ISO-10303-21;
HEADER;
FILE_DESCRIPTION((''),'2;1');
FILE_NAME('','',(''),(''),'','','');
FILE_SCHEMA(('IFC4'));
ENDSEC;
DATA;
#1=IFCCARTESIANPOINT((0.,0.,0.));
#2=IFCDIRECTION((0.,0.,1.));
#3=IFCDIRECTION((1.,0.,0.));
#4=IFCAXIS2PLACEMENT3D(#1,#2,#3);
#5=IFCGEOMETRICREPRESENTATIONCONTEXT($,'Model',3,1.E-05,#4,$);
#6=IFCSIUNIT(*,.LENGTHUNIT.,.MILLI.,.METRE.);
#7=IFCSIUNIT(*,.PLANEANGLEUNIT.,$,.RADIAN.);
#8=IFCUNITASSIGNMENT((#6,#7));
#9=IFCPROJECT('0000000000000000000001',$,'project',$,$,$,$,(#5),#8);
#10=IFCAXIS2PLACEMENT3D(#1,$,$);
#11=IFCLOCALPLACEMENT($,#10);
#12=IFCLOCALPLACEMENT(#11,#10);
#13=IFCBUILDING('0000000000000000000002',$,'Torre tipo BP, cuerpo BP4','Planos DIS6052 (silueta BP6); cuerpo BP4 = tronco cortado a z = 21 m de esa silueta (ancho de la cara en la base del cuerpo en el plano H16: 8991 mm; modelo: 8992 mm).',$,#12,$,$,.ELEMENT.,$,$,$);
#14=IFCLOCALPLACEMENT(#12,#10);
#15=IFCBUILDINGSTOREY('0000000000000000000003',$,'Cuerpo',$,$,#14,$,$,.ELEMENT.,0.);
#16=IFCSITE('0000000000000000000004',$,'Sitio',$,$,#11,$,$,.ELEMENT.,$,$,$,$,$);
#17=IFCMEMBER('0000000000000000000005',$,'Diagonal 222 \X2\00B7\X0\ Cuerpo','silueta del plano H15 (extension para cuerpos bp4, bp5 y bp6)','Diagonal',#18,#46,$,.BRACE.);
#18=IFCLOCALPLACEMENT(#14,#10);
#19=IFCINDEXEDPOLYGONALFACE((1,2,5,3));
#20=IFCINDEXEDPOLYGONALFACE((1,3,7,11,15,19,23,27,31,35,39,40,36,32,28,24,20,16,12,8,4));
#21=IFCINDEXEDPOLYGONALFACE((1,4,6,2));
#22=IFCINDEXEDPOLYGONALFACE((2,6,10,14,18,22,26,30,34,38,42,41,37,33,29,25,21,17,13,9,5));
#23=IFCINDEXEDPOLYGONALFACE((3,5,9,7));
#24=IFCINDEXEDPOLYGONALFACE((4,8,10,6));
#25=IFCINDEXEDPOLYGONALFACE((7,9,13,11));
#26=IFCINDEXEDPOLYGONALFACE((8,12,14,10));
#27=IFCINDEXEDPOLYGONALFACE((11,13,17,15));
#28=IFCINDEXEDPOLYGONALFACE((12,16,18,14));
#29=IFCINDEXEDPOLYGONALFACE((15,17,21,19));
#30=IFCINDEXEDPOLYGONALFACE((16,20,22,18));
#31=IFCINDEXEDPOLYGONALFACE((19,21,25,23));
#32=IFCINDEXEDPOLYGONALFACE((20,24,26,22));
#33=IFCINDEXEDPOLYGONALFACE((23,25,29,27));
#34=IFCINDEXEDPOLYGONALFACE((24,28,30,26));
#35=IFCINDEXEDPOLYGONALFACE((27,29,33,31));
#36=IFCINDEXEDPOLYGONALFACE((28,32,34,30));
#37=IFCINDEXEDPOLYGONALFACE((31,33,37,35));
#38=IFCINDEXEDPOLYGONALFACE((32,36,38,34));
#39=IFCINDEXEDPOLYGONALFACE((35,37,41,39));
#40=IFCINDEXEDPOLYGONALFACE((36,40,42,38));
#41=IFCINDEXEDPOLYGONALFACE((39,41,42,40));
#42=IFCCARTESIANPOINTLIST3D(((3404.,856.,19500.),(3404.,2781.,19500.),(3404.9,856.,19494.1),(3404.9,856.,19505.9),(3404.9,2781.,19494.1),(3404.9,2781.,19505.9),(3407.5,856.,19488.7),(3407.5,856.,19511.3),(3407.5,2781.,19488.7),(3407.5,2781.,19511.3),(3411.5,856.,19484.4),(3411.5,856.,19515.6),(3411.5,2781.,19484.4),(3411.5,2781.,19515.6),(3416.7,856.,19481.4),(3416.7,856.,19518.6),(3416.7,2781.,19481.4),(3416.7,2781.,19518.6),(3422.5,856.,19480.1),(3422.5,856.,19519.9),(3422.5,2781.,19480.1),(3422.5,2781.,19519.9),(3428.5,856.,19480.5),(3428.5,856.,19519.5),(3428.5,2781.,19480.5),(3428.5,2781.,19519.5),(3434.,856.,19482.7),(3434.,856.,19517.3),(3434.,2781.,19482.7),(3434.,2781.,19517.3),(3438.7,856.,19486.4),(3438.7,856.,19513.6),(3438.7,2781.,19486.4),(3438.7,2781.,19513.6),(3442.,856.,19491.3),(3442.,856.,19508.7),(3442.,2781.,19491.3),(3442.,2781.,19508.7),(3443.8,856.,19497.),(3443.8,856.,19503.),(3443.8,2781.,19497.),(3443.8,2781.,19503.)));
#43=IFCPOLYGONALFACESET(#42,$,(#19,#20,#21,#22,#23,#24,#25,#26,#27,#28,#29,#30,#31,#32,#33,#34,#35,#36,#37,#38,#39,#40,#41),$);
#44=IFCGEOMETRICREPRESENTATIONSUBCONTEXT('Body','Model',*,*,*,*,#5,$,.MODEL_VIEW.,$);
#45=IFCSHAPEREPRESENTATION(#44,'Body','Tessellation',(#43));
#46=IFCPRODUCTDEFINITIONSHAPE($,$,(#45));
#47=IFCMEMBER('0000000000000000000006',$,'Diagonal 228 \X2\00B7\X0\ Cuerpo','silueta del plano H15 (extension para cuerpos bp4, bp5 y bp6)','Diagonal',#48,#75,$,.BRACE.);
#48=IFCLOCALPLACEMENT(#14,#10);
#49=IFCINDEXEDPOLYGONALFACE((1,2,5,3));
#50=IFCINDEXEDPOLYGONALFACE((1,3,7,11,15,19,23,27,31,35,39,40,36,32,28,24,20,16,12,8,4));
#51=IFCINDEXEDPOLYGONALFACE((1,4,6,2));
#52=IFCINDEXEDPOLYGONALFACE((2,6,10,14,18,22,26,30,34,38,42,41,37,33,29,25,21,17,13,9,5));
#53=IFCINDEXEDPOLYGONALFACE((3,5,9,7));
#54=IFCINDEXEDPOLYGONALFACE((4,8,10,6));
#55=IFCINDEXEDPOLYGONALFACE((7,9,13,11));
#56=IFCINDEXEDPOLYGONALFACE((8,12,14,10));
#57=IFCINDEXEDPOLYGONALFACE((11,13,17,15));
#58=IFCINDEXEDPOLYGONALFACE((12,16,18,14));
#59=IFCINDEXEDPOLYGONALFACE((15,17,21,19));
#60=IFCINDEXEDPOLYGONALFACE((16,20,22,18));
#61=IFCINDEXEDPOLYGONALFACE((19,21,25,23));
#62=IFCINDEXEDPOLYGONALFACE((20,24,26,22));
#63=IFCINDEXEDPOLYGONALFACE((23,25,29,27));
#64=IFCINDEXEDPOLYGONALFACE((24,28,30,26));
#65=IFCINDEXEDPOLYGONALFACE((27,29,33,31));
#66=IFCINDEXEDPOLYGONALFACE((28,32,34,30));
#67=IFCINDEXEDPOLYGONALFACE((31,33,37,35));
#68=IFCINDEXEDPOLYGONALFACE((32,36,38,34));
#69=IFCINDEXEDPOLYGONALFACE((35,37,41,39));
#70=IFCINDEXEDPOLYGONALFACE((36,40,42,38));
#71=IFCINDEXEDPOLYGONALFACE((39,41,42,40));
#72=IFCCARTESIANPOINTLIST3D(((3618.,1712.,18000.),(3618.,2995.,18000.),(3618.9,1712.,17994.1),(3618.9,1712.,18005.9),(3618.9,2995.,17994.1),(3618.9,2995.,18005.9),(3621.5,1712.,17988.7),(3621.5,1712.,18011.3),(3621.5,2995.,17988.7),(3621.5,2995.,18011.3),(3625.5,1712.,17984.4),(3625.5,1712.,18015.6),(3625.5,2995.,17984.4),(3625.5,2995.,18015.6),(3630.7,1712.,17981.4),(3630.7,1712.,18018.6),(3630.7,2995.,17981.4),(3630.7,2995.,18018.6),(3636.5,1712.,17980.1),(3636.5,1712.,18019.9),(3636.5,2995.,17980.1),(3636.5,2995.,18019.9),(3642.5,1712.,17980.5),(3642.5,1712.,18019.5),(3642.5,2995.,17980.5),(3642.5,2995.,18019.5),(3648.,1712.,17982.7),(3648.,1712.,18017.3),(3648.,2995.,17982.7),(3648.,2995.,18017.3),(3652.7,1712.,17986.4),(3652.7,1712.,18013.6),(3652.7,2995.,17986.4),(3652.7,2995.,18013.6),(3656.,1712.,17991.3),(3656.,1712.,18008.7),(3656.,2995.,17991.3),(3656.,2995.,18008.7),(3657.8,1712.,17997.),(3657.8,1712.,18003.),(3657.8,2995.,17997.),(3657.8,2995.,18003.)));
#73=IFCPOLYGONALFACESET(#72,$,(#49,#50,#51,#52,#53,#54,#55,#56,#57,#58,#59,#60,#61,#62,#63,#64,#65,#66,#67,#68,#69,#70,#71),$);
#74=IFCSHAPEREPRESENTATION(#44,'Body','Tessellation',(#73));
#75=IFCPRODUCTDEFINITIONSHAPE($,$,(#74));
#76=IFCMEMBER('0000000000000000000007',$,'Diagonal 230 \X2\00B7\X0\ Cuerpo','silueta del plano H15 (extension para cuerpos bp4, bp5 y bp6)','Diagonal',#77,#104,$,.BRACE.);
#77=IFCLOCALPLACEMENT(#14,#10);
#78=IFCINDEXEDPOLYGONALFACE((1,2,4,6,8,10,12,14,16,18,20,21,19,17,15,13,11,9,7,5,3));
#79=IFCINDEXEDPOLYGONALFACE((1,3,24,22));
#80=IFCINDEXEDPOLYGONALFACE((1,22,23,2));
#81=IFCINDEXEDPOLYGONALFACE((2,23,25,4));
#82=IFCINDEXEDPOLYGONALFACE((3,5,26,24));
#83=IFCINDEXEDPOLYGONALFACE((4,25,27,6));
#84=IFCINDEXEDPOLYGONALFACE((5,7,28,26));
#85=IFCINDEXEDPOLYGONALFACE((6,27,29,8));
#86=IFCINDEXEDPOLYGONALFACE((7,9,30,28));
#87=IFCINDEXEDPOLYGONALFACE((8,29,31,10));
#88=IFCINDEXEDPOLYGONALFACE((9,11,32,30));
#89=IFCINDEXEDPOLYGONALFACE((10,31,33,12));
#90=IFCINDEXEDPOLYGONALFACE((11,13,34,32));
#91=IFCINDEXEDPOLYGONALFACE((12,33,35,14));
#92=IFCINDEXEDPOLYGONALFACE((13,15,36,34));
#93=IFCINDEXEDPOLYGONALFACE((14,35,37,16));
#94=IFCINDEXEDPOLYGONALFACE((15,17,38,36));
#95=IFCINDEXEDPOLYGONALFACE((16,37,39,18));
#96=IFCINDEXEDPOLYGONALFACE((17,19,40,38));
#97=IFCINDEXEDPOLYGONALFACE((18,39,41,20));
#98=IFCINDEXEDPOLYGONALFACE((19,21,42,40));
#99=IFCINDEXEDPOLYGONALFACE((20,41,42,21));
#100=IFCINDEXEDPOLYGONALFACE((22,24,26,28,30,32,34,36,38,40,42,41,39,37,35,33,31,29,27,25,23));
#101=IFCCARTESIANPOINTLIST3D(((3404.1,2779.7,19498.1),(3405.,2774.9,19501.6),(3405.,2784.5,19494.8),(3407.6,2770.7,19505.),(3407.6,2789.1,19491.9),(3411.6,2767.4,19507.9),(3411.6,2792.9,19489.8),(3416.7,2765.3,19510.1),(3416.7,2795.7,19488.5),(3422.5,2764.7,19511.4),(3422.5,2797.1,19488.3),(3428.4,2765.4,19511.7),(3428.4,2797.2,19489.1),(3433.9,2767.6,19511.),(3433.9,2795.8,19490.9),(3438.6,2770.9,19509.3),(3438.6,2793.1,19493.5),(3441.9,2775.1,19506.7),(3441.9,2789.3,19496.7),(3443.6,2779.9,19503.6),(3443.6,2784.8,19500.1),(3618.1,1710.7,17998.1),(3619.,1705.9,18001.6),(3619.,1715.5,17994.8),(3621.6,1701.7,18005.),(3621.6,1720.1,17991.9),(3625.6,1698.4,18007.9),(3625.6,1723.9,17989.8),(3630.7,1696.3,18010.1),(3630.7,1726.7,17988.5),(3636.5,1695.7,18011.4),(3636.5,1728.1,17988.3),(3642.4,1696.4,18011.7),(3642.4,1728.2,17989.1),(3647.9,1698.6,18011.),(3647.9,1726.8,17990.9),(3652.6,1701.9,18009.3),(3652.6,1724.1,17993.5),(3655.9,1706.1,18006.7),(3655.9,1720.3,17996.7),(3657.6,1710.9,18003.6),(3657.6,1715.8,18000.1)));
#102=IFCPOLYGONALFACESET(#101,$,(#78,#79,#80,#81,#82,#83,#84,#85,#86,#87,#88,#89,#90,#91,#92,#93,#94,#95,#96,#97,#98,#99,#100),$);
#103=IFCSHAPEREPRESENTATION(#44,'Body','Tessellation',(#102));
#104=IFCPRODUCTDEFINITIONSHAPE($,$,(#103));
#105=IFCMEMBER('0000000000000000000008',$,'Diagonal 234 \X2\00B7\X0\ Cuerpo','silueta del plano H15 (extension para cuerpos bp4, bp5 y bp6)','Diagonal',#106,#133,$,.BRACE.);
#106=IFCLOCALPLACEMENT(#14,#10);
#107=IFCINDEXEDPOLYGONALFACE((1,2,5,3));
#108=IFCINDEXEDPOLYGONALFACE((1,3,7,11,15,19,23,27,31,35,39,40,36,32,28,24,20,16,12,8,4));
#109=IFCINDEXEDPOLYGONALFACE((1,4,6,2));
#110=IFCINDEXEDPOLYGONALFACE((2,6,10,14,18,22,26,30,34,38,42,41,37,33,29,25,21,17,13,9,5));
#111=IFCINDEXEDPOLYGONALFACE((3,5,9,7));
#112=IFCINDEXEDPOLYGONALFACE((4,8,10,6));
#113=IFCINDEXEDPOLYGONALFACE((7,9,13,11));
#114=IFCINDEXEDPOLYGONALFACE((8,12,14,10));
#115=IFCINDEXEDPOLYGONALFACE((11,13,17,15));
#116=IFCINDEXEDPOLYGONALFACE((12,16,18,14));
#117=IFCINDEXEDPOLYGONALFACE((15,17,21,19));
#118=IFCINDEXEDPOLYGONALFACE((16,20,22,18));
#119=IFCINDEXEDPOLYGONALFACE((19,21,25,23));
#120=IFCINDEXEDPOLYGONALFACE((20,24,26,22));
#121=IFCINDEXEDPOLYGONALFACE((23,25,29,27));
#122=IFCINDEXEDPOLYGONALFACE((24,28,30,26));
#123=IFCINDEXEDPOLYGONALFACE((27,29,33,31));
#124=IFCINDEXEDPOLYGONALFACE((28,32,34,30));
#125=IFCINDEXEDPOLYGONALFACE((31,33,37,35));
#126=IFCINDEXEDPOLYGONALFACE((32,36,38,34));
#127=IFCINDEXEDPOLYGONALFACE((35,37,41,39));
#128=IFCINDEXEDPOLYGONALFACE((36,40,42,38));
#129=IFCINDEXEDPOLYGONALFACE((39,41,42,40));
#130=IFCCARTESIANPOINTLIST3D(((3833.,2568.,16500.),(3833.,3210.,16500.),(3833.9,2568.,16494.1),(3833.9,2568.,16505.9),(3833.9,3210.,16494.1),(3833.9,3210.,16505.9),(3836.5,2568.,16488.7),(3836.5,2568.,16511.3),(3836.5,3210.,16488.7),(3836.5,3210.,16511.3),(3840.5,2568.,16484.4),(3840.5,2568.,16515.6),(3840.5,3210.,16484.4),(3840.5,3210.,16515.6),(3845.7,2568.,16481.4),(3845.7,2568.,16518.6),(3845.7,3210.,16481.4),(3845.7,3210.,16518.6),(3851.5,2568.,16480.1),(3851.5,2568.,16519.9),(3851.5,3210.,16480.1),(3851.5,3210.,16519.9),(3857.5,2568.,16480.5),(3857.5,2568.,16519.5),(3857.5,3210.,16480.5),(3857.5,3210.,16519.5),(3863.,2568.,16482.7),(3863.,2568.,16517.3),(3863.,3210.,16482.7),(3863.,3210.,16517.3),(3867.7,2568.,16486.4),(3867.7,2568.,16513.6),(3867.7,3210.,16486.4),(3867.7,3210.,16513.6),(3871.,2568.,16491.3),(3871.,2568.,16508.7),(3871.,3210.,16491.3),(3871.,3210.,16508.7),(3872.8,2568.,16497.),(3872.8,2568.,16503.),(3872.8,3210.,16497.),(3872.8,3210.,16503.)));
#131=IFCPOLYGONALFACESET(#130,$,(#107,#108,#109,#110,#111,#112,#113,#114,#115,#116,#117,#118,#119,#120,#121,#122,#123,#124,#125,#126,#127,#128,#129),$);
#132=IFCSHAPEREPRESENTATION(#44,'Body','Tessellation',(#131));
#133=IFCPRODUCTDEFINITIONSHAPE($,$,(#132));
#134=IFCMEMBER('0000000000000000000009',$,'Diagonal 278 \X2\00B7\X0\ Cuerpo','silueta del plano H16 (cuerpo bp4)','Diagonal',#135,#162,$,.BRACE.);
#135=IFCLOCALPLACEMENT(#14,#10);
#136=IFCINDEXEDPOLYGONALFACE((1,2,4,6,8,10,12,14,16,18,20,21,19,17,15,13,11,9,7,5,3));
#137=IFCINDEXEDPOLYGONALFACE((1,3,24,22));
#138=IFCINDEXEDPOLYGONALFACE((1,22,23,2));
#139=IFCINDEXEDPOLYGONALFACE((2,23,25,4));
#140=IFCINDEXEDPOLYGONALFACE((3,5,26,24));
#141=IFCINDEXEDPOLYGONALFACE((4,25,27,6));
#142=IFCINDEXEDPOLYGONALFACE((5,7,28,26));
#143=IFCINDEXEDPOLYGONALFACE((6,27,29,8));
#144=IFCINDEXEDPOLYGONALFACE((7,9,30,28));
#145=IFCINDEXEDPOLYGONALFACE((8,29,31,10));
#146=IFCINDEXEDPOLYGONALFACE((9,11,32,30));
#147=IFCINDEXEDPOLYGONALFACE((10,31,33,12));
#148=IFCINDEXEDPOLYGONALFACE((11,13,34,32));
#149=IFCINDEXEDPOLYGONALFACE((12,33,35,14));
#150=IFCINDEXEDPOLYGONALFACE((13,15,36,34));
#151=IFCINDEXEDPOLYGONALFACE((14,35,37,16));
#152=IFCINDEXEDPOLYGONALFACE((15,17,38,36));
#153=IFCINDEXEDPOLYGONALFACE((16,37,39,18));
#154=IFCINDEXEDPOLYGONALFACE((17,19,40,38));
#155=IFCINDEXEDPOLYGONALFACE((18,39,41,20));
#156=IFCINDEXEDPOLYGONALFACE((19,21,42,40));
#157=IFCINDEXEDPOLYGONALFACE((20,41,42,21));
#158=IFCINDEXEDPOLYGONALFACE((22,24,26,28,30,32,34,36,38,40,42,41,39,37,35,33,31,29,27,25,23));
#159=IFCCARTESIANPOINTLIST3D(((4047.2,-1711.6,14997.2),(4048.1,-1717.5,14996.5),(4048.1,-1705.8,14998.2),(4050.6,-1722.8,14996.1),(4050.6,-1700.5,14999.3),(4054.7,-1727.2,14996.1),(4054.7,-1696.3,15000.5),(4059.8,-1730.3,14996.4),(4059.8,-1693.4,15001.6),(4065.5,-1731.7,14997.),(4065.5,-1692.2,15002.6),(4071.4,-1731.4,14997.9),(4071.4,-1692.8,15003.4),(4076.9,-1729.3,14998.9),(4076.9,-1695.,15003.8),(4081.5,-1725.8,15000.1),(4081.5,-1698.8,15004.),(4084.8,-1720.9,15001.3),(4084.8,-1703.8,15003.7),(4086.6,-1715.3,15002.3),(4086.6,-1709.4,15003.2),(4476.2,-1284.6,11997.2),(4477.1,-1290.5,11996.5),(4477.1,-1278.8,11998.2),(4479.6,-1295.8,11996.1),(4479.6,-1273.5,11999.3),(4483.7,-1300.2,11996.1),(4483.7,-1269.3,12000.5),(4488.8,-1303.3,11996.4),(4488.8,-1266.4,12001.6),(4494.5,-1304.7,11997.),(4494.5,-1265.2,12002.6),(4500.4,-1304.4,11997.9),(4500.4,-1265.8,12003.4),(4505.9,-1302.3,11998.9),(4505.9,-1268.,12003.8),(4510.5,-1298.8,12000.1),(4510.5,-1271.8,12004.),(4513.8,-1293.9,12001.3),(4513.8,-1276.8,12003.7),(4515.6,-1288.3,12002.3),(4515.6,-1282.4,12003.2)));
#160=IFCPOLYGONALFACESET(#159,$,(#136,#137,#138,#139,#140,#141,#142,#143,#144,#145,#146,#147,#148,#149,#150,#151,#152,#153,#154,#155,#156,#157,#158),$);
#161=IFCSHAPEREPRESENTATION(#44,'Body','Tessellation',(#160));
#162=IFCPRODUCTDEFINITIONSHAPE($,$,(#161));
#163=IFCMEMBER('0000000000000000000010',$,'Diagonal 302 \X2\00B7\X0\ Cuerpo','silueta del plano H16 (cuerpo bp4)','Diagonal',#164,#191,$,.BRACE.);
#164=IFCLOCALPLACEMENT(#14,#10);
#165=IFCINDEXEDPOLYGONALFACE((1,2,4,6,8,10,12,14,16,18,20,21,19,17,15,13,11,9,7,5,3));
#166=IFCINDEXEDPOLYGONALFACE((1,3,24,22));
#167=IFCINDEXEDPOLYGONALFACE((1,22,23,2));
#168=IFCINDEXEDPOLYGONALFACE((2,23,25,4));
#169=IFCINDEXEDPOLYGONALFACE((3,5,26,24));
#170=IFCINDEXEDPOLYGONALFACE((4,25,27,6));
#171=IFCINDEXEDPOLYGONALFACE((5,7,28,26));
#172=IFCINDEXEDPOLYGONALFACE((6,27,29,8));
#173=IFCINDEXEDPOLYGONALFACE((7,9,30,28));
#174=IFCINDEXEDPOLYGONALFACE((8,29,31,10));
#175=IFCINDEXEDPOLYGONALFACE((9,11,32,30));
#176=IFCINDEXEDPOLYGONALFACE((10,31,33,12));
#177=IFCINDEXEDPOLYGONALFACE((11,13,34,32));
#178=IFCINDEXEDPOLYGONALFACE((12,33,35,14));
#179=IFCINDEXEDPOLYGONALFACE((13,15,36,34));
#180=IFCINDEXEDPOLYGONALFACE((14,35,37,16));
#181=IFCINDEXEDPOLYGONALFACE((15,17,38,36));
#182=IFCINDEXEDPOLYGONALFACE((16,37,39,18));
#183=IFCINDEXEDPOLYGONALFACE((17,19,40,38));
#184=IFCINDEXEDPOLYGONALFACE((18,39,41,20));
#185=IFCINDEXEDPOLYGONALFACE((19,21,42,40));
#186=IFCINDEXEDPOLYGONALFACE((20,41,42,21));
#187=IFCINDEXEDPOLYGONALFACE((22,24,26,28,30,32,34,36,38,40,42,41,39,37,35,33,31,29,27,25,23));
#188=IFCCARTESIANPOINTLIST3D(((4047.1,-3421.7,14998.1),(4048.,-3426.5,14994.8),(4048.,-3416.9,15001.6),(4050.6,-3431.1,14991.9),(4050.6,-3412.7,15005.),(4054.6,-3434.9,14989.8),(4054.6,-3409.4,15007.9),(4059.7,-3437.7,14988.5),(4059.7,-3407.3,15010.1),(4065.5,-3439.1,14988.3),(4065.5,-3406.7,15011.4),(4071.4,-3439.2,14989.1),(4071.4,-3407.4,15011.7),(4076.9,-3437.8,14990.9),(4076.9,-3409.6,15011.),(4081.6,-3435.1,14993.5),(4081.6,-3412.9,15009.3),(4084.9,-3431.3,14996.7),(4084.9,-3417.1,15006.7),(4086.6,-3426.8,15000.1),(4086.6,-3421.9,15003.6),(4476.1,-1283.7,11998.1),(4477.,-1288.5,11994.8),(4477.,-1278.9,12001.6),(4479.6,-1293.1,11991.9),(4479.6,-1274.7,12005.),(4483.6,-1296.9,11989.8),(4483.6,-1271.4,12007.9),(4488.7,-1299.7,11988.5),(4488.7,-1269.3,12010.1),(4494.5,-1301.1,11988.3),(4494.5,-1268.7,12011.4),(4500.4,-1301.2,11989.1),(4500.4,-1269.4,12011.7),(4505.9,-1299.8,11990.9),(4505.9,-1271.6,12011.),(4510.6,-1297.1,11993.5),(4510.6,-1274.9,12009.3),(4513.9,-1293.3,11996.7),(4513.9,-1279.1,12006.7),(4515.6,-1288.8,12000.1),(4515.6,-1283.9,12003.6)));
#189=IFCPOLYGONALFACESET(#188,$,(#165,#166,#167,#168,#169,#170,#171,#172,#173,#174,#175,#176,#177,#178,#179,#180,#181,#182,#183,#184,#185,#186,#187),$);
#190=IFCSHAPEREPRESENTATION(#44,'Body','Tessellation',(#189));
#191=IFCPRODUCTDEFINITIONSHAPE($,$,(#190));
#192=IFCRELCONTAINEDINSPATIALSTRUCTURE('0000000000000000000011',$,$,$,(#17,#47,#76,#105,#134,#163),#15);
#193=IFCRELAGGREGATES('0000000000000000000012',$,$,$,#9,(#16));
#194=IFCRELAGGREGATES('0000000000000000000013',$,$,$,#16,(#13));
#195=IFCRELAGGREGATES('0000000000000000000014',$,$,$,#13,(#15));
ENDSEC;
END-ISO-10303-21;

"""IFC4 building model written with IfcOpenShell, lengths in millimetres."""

from ifc_helpers import new_model, si_unit, frame, origin, origin_with_axes, place, context, subcontext, project, spatial, circle, extrude, element, save


model = new_model("IFC4")

# Units and contexts
model_context = context("Model", 3, precision=1e-05, world=origin_with_axes())
body_context = subcontext(model_context, "Body", "Model", "MODEL_VIEW")
ifc_project = project(units=[si_unit("LENGTHUNIT", "METRE", prefix="MILLI"), si_unit("PLANEANGLEUNIT", "RADIAN")], contexts=[model_context])

# Site, building, storey
site_placement = place(None, origin())
site = spatial("IfcSite", under=ifc_project, at=site_placement, Name="Sitio", CompositionType="ELEMENT")
building_placement = place(site_placement, origin())
building = spatial("IfcBuilding", under=site, at=building_placement, Name="Torre tipo BP, cuerpo BP4", Description="Planos DIS6052 (silueta BP6); cuerpo BP4 = tronco cortado a z = 21 m de esa silueta (ancho de la cara en la base del cuerpo en el plano H16: 8991 mm; modelo: 8992 mm).", CompositionType="ELEMENT")
storey_placement = place(building_placement, origin())
storey = spatial("IfcBuildingStorey", under=building, at=storey_placement, Name="Cuerpo", CompositionType="ELEMENT", Elevation=0.0)

# Members
member_1_placement = place(storey_placement, frame((3424.0, 856.0, 19500.0), z_axis=(0.0, 1.0, 0.0), x_axis=(-1.0, 0.0, 0.0)))
element("IfcMember", 1, at=member_1_placement, inside=storey, Name="Diagonal 222 · Cuerpo", Description="silueta del plano H15 (extension para cuerpos bp4, bp5 y bp6)", ObjectType="Diagonal", PredefinedType="BRACE", context=body_context, shape_type="SweptSolid", body=[
    extrude(circle(Radius=20.0), None, (0.0, 0.0, 1.0), 1925.0),
])
member_2_placement = place(storey_placement, frame((3638.0, 1712.0, 18000.0), z_axis=(0.0, 1.0, 0.0), x_axis=(-1.0, 0.0, 0.0)))
element("IfcMember", 2, at=member_2_placement, inside=storey, Name="Diagonal 228 · Cuerpo", Description="silueta del plano H15 (extension para cuerpos bp4, bp5 y bp6)", ObjectType="Diagonal", PredefinedType="BRACE", context=body_context, shape_type="SweptSolid", body=[
    extrude(circle(Radius=20.0), None, (0.0, 0.0, 1.0), 1283.0),
])
member_3_placement = place(storey_placement, frame((3638.0, 1712.0, 18000.0), z_axis=(-0.115405, 0.576487, 0.808915), x_axis=(-0.993318, -0.066977, -0.093981)))
element("IfcMember", 3, at=member_3_placement, inside=storey, Name="Diagonal 230 · Cuerpo", Description="silueta del plano H15 (extension para cuerpos bp4, bp5 y bp6)", ObjectType="Diagonal", PredefinedType="BRACE", context=body_context, shape_type="SweptSolid", body=[
    extrude(circle(Radius=20.0), None, (0.0, 0.0, 1.0), 1854.3),
])
member_4_placement = place(storey_placement, frame((3853.0, 2568.0, 16500.0), z_axis=(0.0, 1.0, 0.0), x_axis=(-1.0, 0.0, 0.0)))
element("IfcMember", 4, at=member_4_placement, inside=storey, Name="Diagonal 234 · Cuerpo", Description="silueta del plano H15 (extension para cuerpos bp4, bp5 y bp6)", ObjectType="Diagonal", PredefinedType="BRACE", context=body_context, shape_type="SweptSolid", body=[
    extrude(circle(Radius=20.0), None, (0.0, 0.0, 1.0), 642.0),
])
member_5_placement = place(storey_placement, frame((4067.0, -1712.0, 15000.0), z_axis=(0.140175, 0.139522, -0.980247), x_axis=(-0.990127, 0.019753, -0.138777)))
element("IfcMember", 5, at=member_5_placement, inside=storey, Name="Diagonal 278 · Cuerpo", Description="silueta del plano H16 (cuerpo bp4)", ObjectType="Diagonal", PredefinedType="BRACE", context=body_context, shape_type="SweptSolid", body=[
    extrude(circle(Radius=20.0), None, (0.0, 0.0, 1.0), 3060.5),
])
for number, where, z_axis, x_axis, name in (
    (6, (4067.0, -3423.0, 15000.0), (0.115671, 0.576469, -0.80889), (-0.993288, 0.067132, -0.094198), "Diagonal 302 · Cuerpo"),
):
    element("IfcMember", number, at=place(storey_placement, frame(where, z_axis=z_axis, x_axis=x_axis)), inside=storey, Name=name, Description="silueta del plano H16 (cuerpo bp4)", ObjectType="Diagonal", PredefinedType="BRACE", context=body_context, shape_type="SweptSolid", body=[
        extrude(circle(Radius=20.0), None, (0.0, 0.0, 1.0), 3708.8),
    ])

save(model, "model.ifc")
